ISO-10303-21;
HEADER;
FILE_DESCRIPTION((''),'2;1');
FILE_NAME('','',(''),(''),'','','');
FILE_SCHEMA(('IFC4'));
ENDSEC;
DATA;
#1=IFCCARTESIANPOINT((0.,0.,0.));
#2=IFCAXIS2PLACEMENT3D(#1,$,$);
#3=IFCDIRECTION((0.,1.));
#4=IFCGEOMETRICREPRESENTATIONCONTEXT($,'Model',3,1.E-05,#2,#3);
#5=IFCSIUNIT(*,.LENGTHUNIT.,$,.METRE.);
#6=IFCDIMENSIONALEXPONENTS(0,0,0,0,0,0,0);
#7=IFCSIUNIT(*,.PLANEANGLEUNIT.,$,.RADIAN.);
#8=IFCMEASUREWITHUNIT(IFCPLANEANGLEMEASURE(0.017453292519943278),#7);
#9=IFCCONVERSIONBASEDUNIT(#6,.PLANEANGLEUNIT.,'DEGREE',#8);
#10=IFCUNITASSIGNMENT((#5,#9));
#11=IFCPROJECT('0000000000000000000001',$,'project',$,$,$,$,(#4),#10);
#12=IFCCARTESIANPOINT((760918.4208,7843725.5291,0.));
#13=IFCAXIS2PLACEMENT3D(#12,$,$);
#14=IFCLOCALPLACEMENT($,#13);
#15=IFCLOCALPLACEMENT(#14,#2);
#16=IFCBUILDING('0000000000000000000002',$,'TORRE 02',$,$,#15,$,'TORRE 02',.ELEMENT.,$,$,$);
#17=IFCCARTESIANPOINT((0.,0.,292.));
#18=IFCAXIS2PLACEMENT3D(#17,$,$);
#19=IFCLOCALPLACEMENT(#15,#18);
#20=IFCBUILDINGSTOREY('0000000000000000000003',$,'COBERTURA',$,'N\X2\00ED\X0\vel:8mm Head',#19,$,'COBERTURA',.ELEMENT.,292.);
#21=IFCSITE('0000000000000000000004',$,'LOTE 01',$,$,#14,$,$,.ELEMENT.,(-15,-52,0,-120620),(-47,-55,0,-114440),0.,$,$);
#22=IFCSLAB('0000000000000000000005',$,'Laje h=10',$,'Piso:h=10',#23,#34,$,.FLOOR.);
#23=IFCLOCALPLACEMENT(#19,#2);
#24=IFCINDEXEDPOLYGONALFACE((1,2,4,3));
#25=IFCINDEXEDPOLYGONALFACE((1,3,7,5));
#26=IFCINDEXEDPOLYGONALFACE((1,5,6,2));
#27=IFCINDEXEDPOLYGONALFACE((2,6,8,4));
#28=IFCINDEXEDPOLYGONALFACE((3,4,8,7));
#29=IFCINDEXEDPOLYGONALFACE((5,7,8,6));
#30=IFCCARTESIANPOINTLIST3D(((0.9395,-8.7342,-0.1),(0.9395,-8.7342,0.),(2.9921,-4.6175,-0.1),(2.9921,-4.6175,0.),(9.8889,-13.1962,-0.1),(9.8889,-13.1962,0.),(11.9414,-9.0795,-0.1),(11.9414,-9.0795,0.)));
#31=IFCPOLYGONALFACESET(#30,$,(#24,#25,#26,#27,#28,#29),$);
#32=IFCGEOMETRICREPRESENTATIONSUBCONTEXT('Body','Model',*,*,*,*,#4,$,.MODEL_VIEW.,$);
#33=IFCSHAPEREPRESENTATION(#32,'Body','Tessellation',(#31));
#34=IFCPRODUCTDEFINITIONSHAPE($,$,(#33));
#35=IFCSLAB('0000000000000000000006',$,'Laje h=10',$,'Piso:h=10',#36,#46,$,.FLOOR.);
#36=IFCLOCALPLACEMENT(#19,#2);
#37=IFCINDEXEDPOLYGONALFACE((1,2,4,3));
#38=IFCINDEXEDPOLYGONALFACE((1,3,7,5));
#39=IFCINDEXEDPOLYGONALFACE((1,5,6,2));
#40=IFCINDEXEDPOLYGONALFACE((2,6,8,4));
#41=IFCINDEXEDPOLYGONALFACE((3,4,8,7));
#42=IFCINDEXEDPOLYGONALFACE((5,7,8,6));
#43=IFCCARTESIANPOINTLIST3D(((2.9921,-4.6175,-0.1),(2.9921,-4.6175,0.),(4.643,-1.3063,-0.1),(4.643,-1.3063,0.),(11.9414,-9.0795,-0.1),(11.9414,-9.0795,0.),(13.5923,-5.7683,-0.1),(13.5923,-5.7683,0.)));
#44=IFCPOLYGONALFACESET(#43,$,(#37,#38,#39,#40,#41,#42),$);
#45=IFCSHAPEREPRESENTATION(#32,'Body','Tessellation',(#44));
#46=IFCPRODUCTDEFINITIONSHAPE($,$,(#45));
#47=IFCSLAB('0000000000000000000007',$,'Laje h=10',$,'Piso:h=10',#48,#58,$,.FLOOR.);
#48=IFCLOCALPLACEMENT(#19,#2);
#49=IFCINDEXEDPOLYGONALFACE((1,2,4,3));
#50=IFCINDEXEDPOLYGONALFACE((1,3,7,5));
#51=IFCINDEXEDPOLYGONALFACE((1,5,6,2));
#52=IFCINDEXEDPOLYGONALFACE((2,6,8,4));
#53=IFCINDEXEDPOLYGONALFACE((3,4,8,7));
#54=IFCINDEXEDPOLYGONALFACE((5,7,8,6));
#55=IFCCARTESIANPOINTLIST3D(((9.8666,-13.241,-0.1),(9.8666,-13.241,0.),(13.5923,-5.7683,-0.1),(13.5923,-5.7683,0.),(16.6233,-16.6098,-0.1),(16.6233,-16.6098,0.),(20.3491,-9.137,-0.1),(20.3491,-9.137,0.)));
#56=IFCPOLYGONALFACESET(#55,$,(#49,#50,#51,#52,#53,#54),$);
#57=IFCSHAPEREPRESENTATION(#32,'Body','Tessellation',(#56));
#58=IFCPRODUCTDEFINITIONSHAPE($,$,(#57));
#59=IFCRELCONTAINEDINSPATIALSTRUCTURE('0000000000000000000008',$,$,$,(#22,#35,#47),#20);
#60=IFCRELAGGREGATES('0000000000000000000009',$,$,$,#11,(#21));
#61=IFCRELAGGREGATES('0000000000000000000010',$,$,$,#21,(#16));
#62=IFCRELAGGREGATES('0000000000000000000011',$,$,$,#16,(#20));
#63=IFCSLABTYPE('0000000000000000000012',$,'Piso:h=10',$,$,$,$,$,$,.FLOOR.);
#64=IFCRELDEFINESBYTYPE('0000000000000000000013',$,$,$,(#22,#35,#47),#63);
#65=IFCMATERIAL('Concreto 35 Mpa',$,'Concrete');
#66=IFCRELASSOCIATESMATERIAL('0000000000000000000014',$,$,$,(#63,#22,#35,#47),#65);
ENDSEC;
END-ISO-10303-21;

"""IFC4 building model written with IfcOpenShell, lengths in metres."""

from ifc_helpers import new_model, entity, si_unit, converted_unit, direction, frame, origin, place, context, subcontext, project, spatial, indexed_curve, outline, extrude, material, type_object, element, save


model = new_model("IFC4")

# Units and contexts
model_context = context("Model", 3, precision=1e-05, world=origin(), true_north=direction((0.0, 1.0)))
body_context = subcontext(model_context, "Body", "Model", "MODEL_VIEW")
ifc_project = project(units=[si_unit("LENGTHUNIT", "METRE"), converted_unit("PLANEANGLEUNIT", "DEGREE", entity("IfcPlaneAngleMeasure", 0.017453292519943278), si_unit("PLANEANGLEUNIT", "RADIAN"), dimensions=[0, 0, 0, 0, 0, 0, 0])], contexts=[model_context])

# Site, building, storey
site_placement = place(None, frame((760918.4208, 7843725.5291, 0.0)))
site = spatial("IfcSite", under=ifc_project, at=site_placement, Name="LOTE 01", CompositionType="ELEMENT", RefLatitude=(-15, -52, 0, -120620), RefLongitude=(-47, -55, 0, -114440), RefElevation=0.0)
building_placement = place(site_placement, origin())
building = spatial("IfcBuilding", under=site, at=building_placement, Name="TORRE 02", LongName="TORRE 02", CompositionType="ELEMENT")
storey_placement = place(building_placement, frame((0.0, 0.0, 292.0)))
storey = spatial("IfcBuildingStorey", under=building, at=storey_placement, Name="COBERTURA", ObjectType="Nível:8mm Head", LongName="COBERTURA", CompositionType="ELEMENT", Elevation=292.0)

# Slabs
ifc_material_1 = material(Name="Concreto 35 Mpa", Category="Concrete")
slab_type = type_object("IfcSlabType", Name="Piso:h=10", PredefinedType="FLOOR", material=ifc_material_1)
slab_1_placement = place(storey_placement, origin())
element("IfcSlab", 1, at=slab_1_placement, inside=storey, type_object=slab_type, material=ifc_material_1, Name="Laje h=10", ObjectType="Piso:h=10", PredefinedType="FLOOR", context=body_context, shape_type="SweptSolid", body=[
    extrude(outline(indexed_curve([(-2.3, -5.0), (2.3, -5.0), (2.3, 5.0), (-2.3, 5.0), (-2.3, -5.0)], self_intersect=False)), frame((6.4405, -8.9069, 0.0), z_axis=(0.0, 0.0, -1.0), x_axis=(-0.446198, -0.894934, 0.0)), (0.0, 0.0, 1.0), 0.1),
])
slab_2_placement = place(storey_placement, origin())
element("IfcSlab", 2, at=slab_2_placement, inside=storey, type_object=slab_type, material=ifc_material_1, Name="Laje h=10", ObjectType="Piso:h=10", PredefinedType="FLOOR", context=body_context, shape_type="SweptSolid", body=[
    extrude(outline(indexed_curve([(-1.85, -5.0), (1.85, -5.0), (1.85, 5.0), (-1.85, 5.0), (-1.85, -5.0)], self_intersect=False)), frame((8.2922, -5.1929, 0.0), z_axis=(0.0, 0.0, -1.0), x_axis=(-0.446198, -0.894934, 0.0)), (0.0, 0.0, 1.0), 0.1),
])
slab_3_placement = place(storey_placement, origin())
element("IfcSlab", 3, at=slab_3_placement, inside=storey, type_object=slab_type, material=ifc_material_1, Name="Laje h=10", ObjectType="Piso:h=10", PredefinedType="FLOOR", context=body_context, shape_type="SweptSolid", body=[
    extrude(outline(indexed_curve([(-4.175, -3.775), (4.175, -3.775), (4.175, 3.775), (-4.175, 3.775), (-4.175, -3.775)], self_intersect=False)), frame((15.1078, -11.189, 0.0), z_axis=(0.0, 0.0, -1.0), x_axis=(-0.446198, -0.894934, 0.0)), (0.0, 0.0, 1.0), 0.1),
])

save(model, "model.ifc")
